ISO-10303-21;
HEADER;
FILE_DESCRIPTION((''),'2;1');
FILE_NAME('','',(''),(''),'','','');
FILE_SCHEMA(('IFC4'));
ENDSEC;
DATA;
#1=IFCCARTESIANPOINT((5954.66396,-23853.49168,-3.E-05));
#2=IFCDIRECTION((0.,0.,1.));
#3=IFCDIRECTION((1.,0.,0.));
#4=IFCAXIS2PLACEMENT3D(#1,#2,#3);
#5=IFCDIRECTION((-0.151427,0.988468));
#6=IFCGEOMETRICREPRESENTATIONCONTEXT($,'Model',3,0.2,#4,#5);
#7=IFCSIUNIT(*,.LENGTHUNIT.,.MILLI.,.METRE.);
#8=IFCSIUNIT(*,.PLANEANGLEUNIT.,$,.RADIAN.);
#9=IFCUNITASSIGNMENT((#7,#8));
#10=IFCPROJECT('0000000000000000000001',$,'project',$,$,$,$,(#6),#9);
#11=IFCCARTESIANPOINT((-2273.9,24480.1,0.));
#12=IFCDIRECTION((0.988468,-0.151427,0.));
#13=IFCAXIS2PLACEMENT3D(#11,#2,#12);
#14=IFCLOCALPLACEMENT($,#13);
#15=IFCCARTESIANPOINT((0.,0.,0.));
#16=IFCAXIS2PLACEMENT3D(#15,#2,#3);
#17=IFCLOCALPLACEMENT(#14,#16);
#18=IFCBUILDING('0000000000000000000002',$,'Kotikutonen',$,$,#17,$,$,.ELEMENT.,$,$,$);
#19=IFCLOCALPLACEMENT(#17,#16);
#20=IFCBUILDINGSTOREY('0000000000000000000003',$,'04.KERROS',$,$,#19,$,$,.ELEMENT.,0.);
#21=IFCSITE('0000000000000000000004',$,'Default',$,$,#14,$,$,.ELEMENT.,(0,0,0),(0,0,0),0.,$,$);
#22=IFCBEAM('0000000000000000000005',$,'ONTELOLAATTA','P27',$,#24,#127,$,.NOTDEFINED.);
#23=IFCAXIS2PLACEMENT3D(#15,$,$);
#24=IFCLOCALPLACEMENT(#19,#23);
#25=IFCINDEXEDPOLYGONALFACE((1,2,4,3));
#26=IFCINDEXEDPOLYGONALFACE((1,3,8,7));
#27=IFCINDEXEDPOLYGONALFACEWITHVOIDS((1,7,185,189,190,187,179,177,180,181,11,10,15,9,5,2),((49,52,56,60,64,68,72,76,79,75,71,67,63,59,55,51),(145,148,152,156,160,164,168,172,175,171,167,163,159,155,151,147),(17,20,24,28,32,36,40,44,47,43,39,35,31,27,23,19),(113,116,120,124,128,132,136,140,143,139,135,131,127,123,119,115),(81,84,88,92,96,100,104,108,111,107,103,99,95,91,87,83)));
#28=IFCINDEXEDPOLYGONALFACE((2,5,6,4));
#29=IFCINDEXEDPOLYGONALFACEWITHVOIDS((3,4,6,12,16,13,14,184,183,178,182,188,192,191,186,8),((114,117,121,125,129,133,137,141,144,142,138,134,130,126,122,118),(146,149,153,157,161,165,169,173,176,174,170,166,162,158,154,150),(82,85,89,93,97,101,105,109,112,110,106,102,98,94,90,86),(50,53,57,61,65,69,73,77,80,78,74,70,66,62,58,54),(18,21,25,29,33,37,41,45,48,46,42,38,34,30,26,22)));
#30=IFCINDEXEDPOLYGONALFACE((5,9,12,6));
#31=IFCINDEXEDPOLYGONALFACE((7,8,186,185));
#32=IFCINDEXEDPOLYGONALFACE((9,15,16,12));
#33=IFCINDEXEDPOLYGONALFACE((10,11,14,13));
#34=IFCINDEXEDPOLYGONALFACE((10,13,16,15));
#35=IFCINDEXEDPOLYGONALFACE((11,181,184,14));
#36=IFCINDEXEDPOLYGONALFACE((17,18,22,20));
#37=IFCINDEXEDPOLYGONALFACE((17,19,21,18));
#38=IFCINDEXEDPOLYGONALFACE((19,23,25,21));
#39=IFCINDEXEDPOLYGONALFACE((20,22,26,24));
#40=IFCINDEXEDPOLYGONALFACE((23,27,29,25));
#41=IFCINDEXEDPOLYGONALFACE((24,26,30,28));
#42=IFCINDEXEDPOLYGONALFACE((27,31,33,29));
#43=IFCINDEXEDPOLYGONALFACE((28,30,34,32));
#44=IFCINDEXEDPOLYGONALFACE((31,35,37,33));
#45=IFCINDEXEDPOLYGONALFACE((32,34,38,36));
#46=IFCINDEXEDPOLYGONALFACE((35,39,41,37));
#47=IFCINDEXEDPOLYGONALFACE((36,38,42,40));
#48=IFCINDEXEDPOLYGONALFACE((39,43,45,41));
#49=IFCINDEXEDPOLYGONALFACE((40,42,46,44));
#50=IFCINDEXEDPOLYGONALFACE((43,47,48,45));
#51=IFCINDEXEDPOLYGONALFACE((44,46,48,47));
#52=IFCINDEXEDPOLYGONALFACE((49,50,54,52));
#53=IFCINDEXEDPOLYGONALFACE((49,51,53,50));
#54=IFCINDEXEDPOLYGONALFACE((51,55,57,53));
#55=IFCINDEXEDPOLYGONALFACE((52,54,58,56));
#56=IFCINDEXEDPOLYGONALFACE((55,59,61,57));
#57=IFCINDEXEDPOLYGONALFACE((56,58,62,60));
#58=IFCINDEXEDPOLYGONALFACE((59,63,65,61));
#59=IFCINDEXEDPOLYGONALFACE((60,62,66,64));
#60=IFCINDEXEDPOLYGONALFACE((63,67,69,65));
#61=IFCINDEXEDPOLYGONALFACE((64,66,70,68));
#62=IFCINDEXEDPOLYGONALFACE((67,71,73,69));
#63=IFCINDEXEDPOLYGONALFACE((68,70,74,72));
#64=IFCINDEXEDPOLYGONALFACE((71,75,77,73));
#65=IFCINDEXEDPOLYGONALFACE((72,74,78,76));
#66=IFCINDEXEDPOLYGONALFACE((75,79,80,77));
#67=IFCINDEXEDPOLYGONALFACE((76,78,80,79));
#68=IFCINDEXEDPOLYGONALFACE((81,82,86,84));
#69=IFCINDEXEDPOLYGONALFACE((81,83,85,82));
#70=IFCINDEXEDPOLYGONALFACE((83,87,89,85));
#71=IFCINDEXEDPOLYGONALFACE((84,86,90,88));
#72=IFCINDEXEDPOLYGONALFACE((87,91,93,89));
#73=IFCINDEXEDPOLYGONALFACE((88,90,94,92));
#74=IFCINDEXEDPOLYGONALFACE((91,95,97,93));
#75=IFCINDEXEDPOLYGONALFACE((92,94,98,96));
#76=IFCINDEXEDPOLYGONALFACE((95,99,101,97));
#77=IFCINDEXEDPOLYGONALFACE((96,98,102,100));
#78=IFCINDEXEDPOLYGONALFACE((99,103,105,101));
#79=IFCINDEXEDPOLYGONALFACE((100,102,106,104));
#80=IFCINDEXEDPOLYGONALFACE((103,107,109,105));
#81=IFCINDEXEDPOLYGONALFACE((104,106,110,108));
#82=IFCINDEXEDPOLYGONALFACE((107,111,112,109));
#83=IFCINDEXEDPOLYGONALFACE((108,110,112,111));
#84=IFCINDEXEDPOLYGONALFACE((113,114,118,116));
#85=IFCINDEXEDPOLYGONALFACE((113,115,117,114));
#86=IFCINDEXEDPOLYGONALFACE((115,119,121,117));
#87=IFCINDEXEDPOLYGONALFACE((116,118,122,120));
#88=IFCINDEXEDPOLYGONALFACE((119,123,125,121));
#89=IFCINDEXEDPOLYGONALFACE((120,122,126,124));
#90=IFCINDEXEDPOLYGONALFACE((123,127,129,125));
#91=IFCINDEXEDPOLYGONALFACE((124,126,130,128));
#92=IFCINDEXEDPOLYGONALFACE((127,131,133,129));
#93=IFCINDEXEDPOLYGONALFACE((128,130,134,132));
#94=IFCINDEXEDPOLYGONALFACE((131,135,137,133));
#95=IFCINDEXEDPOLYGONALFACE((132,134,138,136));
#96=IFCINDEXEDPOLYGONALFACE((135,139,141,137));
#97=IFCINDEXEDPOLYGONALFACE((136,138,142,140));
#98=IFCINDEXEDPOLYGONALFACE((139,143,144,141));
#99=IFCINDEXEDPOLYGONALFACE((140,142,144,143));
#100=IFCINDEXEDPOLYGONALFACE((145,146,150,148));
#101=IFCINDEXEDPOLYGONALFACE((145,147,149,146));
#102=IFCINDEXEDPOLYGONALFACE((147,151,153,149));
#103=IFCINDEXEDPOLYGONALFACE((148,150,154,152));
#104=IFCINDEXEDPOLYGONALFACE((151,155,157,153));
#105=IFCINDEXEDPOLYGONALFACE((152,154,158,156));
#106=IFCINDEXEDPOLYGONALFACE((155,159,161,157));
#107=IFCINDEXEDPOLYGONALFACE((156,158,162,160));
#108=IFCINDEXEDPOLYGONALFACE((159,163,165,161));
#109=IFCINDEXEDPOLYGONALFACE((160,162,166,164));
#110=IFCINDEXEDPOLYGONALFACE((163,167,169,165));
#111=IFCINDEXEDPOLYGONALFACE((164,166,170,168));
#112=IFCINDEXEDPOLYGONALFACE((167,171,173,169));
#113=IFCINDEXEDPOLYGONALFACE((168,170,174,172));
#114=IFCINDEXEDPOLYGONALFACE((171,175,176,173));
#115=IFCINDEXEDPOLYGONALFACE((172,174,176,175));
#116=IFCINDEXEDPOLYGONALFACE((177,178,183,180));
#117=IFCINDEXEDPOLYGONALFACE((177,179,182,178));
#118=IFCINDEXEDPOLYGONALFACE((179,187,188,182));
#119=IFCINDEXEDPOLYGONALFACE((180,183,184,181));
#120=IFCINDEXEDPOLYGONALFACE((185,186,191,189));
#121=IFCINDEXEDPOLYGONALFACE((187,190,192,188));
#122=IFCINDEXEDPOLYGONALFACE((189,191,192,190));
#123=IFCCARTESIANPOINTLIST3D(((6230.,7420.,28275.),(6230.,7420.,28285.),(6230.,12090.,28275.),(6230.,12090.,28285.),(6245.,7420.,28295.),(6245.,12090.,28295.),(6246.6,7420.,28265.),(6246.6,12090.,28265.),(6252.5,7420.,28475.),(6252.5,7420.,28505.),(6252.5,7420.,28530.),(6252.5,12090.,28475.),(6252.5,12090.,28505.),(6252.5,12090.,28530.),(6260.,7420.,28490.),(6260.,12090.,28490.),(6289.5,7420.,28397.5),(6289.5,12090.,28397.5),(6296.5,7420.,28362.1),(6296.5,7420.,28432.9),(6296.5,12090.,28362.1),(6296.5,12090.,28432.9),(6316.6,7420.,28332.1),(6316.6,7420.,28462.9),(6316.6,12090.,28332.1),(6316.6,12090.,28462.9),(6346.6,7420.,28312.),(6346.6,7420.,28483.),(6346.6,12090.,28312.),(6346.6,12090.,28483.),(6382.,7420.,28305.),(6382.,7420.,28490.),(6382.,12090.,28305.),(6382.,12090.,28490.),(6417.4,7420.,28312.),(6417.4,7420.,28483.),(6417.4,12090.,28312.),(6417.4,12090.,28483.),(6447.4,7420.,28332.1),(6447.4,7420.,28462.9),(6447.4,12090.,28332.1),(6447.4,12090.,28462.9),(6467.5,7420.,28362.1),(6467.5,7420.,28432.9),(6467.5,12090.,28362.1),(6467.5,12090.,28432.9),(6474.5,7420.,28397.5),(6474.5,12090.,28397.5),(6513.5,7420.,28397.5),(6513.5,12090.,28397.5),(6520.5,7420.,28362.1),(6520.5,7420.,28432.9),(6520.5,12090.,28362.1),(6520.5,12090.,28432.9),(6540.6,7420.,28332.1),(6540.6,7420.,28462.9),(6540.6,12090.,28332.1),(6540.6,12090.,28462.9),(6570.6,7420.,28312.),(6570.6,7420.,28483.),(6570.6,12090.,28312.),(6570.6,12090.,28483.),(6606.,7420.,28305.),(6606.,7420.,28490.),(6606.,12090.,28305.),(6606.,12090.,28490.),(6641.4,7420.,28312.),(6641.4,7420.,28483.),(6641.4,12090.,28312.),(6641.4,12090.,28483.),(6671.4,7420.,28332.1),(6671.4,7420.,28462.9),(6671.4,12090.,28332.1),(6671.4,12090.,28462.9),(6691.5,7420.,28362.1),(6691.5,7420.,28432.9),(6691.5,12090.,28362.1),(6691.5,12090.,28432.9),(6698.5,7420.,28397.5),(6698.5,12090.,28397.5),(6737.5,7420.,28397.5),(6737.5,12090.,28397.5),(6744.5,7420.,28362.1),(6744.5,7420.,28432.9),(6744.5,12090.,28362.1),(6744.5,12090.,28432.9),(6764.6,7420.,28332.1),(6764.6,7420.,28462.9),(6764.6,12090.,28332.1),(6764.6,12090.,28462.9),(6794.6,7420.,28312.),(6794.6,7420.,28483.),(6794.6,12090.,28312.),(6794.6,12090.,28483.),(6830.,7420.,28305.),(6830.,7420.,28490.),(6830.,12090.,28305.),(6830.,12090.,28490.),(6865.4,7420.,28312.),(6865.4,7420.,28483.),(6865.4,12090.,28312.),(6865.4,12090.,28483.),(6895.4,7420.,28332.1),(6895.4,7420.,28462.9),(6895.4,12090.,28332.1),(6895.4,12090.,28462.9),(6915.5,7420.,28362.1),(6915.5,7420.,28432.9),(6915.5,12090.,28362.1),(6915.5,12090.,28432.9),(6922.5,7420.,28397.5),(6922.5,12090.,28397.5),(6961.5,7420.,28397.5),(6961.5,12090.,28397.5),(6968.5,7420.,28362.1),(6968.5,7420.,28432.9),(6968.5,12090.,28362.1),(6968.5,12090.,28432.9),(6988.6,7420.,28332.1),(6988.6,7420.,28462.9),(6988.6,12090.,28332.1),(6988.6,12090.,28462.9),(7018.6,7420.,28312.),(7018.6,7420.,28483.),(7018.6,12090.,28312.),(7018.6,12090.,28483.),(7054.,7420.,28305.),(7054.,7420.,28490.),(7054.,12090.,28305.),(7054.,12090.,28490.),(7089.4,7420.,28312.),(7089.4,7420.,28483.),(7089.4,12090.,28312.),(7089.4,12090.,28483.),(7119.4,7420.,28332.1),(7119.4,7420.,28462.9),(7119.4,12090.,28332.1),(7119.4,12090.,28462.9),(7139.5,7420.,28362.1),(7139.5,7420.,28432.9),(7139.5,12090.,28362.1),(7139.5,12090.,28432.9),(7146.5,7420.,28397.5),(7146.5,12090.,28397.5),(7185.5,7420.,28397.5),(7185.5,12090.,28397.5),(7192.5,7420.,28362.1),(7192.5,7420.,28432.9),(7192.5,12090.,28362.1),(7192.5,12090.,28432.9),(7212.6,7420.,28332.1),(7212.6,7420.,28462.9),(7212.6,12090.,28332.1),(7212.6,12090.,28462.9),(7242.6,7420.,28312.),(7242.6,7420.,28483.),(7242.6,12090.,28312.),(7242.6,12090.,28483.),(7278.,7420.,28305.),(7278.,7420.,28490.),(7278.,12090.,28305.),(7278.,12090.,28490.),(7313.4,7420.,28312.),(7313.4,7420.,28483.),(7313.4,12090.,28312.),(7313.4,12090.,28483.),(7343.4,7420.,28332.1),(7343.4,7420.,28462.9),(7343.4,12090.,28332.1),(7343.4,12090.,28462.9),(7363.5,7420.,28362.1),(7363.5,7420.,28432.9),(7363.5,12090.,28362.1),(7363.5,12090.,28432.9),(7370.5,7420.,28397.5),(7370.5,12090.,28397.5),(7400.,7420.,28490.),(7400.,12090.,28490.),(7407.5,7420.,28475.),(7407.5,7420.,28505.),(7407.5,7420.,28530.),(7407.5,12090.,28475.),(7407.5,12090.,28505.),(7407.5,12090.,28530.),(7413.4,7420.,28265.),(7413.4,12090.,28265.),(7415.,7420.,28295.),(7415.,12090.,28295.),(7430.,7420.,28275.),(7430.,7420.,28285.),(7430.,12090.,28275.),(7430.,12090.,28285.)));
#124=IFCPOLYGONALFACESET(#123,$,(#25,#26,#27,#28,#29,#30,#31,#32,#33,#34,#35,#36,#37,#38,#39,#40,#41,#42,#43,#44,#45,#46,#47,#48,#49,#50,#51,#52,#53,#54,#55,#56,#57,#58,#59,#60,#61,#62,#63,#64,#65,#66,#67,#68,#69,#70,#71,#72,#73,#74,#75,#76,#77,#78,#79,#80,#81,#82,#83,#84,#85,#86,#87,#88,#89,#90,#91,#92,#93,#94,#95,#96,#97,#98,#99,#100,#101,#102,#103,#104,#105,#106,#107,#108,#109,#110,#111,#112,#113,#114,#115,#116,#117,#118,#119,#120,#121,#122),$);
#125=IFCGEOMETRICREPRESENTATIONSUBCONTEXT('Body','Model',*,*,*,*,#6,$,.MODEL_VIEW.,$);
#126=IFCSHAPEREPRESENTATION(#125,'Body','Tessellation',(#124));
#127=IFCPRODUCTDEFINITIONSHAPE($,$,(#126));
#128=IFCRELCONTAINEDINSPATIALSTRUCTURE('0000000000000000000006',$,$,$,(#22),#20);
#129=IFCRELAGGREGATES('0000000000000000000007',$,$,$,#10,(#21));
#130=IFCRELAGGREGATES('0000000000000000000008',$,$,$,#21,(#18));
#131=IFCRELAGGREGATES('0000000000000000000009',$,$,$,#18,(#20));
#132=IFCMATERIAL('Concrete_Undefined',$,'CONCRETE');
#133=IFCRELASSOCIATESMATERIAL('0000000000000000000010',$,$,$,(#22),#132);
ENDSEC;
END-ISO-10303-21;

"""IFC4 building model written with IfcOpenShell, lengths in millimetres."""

from ifc_helpers import new_model, si_unit, direction, frame, origin_with_axes, place, context, subcontext, project, spatial, line, indexed_curve, outline, extrude, material, element, save


model = new_model("IFC4")

# Units and contexts
model_context = context("Model", 3, precision=0.2, world=frame((5954.66396, -23853.49168, -3e-05), z_axis=(0.0, 0.0, 1.0), x_axis=(1.0, 0.0, 0.0)), true_north=direction((-0.151427, 0.988468)))
body_context = subcontext(model_context, "Body", "Model", "MODEL_VIEW")
ifc_project = project(units=[si_unit("LENGTHUNIT", "METRE", prefix="MILLI"), si_unit("PLANEANGLEUNIT", "RADIAN")], contexts=[model_context])

# Site, building, storey
site_placement = place(None, frame((-2273.9, 24480.1, 0.0), z_axis=(0.0, 0.0, 1.0), x_axis=(0.988468, -0.151427, 0.0)))
site = spatial("IfcSite", under=ifc_project, at=site_placement, Name="Default", CompositionType="ELEMENT", RefLatitude=(0, 0, 0), RefLongitude=(0, 0, 0), RefElevation=0.0)
building_placement = place(site_placement, origin_with_axes())
building = spatial("IfcBuilding", under=site, at=building_placement, Name="Kotikutonen", CompositionType="ELEMENT")
storey_placement = place(building_placement, origin_with_axes())
storey = spatial("IfcBuildingStorey", under=building, at=storey_placement, Name="04.KERROS", CompositionType="ELEMENT", Elevation=0.0)

# Beam
ifc_material_1 = material(Name="Concrete_Undefined", Category="CONCRETE")
beam_1_placement = place(storey_placement, frame((6830.0, 12090.0, 28397.5), z_axis=(-1.0, 0.0, 0.0), x_axis=(0.0, -1.0, 0.0)))
element("IfcBeam", 1, at=beam_1_placement, inside=storey, material=ifc_material_1, Name="ONTELOLAATTA", Description="P27", PredefinedType="NOTDEFINED", context=body_context, shape_type="SolidModel", body=[
    extrude(outline(indexed_curve([(-600.0, -122.5), (-583.4, -132.5), (583.4, -132.5), (600.0, -122.5), (600.0, -112.5), (585.0, -102.5), (577.5, 77.5), (570.0, 92.5), (577.5, 107.5), (577.5, 132.5), (-577.5, 132.5), (-577.5, 107.5), (-570.0, 92.5), (-577.5, 77.5), (-585.0, -102.5), (-600.0, -112.5)], segments=[line(1, 2, 3, 4, 5, 6, 7, 8, 9, 10, 11, 12, 13, 14, 15, 16, 1)]), holes=[indexed_curve([(-448.0, -92.5), (-483.4, -85.5), (-513.4, -65.4), (-533.5, -35.4), (-540.5, 0.0), (-533.5, 35.4), (-513.4, 65.4), (-483.4, 85.5), (-448.0, 92.5), (-412.6, 85.5), (-382.6, 65.4), (-362.5, 35.4), (-355.5, 0.0), (-362.5, -35.4), (-382.6, -65.4), (-412.6, -85.5)], segments=[line(1, 2, 3, 4, 5, 6, 7, 8, 9, 10, 11, 12, 13, 14, 15, 16, 1)]), indexed_curve([(-224.0, -92.5), (-259.4, -85.5), (-289.4, -65.4), (-309.5, -35.4), (-316.5, 0.0), (-309.5, 35.4), (-289.4, 65.4), (-259.4, 85.5), (-224.0, 92.5), (-188.6, 85.5), (-158.6, 65.4), (-138.5, 35.4), (-131.5, 0.0), (-138.5, -35.4), (-158.6, -65.4), (-188.6, -85.5)], segments=[line(1, 2, 3, 4, 5, 6, 7, 8, 9, 10, 11, 12, 13, 14, 15, 16, 1)]), indexed_curve([(0.0, -92.5), (-35.4, -85.5), (-65.4, -65.4), (-85.5, -35.4), (-92.5, 0.0), (-85.5, 35.4), (-65.4, 65.4), (-35.4, 85.5), (0.0, 92.5), (35.4, 85.5), (65.4, 65.4), (85.5, 35.4), (92.5, 0.0), (85.5, -35.4), (65.4, -65.4), (35.4, -85.5)], segments=[line(1, 2, 3, 4, 5, 6, 7, 8, 9, 10, 11, 12, 13, 14, 15, 16, 1)]), indexed_curve([(224.0, -92.5), (188.6, -85.5), (158.6, -65.4), (138.5, -35.4), (131.5, 0.0), (138.5, 35.4), (158.6, 65.4), (188.6, 85.5), (224.0, 92.5), (259.4, 85.5), (289.4, 65.4), (309.5, 35.4), (316.5, 0.0), (309.5, -35.4), (289.4, -65.4), (259.4, -85.5)], segments=[line(1, 2, 3, 4, 5, 6, 7, 8, 9, 10, 11, 12, 13, 14, 15, 16, 1)]), indexed_curve([(448.0, -92.5), (412.6, -85.5), (382.6, -65.4), (362.5, -35.4), (355.5, 0.0), (362.5, 35.4), (382.6, 65.4), (412.6, 85.5), (448.0, 92.5), (483.4, 85.5), (513.4, 65.4), (533.5, 35.4), (540.5, 0.0), (533.5, -35.4), (513.4, -65.4), (483.4, -85.5)], segments=[line(1, 2, 3, 4, 5, 6, 7, 8, 9, 10, 11, 12, 13, 14, 15, 16, 1)])]), frame((0.0, 0.0, 0.0), z_axis=(-1.0, 0.0, 0.0), x_axis=(0.0, 0.0, 1.0)), (0.0, 0.0, -1.0), 4670.0),
])

save(model, "model.ifc")
